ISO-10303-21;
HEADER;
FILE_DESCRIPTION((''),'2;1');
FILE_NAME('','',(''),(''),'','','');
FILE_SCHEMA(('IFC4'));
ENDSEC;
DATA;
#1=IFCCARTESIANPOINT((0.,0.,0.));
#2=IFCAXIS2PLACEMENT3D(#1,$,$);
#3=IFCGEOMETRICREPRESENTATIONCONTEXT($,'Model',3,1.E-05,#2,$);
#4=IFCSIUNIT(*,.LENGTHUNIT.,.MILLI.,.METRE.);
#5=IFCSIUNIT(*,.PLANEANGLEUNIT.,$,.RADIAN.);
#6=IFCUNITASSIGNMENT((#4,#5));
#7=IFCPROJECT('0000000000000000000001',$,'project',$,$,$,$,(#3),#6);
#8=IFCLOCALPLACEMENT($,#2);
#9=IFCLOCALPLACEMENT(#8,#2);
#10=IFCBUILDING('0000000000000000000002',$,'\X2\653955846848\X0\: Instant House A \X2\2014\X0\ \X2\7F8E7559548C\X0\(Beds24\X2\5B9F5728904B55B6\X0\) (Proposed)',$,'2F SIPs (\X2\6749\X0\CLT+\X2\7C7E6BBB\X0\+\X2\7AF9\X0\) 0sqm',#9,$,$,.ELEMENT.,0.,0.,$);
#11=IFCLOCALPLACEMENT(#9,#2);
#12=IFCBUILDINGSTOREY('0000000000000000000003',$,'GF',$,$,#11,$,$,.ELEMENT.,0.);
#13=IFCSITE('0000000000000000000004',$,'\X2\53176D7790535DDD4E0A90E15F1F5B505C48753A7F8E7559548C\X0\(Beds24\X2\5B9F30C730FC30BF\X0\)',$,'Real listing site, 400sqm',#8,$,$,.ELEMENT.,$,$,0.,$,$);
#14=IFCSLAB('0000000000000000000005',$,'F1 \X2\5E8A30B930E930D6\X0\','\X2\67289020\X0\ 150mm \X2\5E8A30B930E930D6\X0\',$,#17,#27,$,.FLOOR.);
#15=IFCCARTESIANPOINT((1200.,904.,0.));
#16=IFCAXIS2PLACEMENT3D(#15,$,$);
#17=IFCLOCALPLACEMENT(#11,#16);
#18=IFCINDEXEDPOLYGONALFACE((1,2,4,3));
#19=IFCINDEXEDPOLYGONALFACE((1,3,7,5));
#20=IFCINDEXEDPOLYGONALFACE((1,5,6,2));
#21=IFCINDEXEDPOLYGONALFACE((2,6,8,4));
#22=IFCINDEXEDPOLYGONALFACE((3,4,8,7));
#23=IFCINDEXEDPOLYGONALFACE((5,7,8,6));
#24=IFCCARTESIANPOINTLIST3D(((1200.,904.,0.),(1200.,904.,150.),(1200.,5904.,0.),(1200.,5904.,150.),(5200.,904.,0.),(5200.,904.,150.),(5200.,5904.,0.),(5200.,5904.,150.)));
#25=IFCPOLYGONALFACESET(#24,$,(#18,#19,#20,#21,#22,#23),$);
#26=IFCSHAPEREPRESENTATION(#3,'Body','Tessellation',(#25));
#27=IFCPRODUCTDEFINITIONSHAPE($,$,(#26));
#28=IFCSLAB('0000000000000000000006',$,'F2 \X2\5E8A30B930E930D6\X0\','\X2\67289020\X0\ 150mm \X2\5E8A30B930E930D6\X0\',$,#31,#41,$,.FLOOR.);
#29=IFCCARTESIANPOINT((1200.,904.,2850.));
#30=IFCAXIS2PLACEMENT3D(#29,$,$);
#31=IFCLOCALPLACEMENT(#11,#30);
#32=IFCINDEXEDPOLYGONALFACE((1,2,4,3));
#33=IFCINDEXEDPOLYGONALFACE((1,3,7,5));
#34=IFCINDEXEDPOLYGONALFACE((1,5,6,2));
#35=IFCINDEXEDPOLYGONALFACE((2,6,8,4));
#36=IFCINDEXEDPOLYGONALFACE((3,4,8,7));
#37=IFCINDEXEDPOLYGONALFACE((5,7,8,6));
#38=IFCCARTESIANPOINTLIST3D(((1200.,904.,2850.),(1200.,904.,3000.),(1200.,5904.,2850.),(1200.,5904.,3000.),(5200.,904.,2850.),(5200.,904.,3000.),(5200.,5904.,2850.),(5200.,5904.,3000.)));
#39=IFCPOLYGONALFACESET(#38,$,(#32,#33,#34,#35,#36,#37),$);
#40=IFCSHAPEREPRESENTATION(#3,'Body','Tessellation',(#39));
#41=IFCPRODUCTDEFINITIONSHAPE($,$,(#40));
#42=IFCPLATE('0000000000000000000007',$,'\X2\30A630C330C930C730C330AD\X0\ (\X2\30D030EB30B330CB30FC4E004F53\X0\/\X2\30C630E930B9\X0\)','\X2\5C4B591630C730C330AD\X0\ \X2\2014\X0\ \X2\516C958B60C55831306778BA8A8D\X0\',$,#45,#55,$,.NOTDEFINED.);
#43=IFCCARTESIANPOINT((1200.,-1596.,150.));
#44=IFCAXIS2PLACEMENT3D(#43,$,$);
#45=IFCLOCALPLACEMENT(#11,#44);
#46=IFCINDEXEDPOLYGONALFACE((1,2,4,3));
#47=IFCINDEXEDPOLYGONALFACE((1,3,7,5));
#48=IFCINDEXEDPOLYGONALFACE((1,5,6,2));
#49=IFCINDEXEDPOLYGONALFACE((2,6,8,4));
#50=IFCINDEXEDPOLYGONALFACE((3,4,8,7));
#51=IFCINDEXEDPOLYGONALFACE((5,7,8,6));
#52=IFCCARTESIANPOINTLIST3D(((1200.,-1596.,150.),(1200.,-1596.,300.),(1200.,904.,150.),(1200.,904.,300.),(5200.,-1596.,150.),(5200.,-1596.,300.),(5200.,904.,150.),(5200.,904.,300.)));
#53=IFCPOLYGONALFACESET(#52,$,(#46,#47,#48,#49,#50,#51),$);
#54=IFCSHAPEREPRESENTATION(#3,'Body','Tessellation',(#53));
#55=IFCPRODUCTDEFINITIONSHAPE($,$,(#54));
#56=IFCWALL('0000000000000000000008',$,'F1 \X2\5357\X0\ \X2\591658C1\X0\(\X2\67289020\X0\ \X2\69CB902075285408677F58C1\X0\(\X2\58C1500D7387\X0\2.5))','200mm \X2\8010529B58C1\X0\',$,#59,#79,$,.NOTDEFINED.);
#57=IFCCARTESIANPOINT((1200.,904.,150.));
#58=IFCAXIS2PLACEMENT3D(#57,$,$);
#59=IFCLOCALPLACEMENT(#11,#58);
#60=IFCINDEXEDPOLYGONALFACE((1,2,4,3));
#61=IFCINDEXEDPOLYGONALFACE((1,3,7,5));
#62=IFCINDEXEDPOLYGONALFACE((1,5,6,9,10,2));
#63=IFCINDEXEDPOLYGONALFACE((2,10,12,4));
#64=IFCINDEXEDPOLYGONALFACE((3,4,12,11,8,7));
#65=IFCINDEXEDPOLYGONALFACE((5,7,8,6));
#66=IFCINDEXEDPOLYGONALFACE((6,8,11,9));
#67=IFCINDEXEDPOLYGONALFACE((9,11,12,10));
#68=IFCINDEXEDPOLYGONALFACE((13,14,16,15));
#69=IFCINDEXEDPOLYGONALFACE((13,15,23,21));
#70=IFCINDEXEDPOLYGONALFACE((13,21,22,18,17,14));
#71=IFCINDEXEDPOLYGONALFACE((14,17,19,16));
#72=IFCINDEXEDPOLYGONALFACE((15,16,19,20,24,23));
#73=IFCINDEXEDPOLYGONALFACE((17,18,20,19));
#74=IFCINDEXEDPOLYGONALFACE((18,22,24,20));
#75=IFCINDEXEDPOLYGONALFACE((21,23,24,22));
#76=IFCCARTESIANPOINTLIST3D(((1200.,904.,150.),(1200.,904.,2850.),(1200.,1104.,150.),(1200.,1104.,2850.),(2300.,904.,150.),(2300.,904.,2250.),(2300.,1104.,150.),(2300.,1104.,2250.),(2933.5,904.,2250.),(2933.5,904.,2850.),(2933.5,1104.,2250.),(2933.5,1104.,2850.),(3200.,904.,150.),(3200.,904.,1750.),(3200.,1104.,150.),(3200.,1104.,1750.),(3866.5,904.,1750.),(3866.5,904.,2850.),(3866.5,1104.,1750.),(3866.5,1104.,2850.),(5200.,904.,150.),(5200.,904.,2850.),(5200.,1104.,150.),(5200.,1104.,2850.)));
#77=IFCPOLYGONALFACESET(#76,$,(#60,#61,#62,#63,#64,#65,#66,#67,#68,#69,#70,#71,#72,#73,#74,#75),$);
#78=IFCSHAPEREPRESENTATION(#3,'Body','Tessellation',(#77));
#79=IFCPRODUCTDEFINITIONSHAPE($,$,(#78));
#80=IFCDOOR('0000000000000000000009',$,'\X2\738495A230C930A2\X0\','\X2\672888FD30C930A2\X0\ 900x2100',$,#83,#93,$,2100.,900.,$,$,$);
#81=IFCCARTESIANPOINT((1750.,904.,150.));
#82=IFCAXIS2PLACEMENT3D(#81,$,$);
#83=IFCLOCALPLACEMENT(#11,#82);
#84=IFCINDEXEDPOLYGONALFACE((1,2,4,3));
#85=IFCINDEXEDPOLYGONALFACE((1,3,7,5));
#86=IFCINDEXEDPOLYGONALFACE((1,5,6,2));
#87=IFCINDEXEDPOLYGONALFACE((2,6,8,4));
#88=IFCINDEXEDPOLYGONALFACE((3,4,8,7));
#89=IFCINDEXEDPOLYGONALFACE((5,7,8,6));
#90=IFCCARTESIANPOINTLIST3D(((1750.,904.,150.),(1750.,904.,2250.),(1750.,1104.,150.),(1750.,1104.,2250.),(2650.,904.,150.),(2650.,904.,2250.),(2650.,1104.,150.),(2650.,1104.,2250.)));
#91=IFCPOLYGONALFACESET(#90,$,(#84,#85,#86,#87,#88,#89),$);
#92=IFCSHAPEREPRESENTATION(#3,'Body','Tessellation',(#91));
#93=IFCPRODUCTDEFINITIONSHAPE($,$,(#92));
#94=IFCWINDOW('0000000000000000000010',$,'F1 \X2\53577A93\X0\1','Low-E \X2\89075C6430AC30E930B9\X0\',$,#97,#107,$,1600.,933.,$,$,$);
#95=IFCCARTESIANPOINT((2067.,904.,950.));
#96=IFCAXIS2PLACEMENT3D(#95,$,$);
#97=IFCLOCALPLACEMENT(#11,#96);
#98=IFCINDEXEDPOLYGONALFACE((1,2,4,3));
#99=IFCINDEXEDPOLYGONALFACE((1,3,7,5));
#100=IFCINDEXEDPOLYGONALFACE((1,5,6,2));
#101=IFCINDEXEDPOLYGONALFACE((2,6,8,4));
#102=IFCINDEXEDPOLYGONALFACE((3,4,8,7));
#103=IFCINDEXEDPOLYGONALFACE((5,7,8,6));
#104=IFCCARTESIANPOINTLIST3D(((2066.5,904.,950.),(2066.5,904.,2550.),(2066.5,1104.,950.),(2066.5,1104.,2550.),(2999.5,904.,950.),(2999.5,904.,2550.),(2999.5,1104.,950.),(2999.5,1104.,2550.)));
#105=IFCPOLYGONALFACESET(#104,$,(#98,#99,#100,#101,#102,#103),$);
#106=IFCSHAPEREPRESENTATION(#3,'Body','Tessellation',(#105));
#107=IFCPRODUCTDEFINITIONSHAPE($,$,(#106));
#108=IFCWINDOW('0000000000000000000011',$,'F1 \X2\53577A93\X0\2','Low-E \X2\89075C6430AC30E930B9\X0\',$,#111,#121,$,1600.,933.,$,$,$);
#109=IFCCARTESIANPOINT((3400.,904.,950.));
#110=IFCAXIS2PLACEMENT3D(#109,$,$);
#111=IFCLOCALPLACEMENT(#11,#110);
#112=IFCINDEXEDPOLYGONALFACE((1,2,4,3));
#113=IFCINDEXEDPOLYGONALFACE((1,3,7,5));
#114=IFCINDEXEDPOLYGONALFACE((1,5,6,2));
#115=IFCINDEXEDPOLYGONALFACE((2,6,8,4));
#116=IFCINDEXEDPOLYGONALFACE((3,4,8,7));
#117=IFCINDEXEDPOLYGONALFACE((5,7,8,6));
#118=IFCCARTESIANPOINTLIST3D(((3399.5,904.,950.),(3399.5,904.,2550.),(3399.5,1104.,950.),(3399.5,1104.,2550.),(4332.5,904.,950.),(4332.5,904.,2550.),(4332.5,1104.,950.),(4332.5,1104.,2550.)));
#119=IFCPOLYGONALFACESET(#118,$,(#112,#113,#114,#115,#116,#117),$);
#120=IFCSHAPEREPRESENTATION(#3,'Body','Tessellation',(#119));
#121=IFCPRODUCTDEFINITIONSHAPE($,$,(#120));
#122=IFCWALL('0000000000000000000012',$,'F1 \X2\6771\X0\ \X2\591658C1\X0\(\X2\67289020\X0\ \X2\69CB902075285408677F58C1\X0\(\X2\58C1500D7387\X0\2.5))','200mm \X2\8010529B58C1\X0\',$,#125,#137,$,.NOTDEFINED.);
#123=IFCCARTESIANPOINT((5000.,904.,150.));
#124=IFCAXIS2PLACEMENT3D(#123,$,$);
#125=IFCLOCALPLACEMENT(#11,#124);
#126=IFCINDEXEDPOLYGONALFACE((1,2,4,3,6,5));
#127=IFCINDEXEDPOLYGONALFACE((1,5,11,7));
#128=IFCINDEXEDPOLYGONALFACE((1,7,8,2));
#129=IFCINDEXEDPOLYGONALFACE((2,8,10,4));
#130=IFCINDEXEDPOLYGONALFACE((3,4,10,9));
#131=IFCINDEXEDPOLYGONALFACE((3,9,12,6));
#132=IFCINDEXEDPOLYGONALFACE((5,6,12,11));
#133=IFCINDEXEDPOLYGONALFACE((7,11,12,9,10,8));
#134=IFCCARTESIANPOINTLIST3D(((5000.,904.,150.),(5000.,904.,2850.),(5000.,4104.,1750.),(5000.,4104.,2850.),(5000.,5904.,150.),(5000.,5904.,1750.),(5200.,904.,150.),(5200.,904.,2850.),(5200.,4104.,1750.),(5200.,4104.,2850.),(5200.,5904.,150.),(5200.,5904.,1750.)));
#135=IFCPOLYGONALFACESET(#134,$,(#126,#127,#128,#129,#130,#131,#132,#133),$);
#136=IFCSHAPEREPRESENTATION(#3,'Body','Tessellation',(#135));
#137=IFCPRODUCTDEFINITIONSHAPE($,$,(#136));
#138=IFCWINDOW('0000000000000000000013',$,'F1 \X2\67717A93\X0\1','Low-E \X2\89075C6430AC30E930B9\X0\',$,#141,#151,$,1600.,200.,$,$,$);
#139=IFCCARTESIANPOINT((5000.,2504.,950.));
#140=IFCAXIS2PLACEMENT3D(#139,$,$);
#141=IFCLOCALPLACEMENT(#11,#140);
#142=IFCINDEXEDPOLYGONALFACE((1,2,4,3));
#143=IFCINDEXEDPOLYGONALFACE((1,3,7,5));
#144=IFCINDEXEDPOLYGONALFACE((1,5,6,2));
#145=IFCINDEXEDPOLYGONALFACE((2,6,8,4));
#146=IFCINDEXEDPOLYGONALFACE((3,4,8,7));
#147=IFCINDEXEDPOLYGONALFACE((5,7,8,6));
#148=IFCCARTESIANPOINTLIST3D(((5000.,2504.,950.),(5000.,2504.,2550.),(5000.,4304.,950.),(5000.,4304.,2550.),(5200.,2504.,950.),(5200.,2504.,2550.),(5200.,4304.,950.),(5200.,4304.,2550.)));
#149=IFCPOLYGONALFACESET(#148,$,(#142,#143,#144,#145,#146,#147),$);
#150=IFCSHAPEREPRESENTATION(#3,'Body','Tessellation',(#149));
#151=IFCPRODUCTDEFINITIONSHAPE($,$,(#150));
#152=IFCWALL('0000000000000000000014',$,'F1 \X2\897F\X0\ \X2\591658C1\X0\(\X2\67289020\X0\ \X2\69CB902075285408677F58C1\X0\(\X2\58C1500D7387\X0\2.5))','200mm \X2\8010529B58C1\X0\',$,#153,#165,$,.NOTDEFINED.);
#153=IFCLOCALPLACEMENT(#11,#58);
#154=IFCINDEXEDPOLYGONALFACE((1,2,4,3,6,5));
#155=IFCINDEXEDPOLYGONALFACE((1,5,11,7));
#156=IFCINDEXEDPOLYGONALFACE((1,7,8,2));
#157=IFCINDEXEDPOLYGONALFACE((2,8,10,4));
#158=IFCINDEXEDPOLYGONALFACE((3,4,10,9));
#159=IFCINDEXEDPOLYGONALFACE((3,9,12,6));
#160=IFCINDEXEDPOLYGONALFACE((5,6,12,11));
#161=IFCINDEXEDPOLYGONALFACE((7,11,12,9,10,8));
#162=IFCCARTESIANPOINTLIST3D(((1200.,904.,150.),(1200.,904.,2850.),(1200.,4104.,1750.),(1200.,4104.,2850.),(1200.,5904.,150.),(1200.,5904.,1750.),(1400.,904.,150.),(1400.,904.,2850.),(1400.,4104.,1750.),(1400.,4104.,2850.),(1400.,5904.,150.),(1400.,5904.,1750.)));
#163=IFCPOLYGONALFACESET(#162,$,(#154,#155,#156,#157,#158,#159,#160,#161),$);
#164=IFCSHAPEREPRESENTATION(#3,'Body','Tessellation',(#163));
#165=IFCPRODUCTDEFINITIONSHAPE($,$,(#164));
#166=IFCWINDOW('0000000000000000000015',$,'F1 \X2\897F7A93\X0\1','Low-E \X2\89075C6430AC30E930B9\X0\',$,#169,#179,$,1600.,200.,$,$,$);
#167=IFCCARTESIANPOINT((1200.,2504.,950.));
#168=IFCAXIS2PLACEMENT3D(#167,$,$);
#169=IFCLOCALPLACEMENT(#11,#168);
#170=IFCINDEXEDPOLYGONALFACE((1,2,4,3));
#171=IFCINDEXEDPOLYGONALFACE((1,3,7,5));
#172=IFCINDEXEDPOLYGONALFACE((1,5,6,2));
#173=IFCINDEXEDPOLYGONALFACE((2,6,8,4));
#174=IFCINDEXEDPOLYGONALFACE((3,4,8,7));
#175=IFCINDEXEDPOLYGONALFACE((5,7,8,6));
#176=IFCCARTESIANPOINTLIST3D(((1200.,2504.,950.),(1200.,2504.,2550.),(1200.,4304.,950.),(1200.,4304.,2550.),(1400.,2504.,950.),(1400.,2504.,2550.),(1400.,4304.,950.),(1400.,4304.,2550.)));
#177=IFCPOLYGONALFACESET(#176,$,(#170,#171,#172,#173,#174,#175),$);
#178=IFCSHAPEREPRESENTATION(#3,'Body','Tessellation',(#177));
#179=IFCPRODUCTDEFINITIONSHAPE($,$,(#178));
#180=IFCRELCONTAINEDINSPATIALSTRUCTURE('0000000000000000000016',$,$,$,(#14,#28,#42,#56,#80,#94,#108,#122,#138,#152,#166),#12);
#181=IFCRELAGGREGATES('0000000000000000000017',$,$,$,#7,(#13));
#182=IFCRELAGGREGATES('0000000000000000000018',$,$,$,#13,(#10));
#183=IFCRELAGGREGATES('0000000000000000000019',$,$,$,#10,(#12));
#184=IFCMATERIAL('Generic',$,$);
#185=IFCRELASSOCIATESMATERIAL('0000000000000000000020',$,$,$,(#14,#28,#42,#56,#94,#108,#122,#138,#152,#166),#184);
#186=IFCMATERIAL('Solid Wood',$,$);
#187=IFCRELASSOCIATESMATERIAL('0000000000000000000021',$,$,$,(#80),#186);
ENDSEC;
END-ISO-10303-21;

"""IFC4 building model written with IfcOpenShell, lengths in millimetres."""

from ifc_helpers import new_model, si_unit, frame, frame_2d, origin, place, context, project, spatial, rectangle, extrude, material, element, fill, save


model = new_model("IFC4")

# Units and contexts
model_context = context("Model", 3, precision=1e-05, world=origin())
ifc_project = project(units=[si_unit("LENGTHUNIT", "METRE", prefix="MILLI"), si_unit("PLANEANGLEUNIT", "RADIAN")], contexts=[model_context])

# Site, building, storey
site_placement = place(None, origin())
site = spatial("IfcSite", under=ifc_project, at=site_placement, Name="北海道川上郡弟子屈町美留和(Beds24実データ)", ObjectType="Real listing site, 400sqm", CompositionType="ELEMENT", RefElevation=0.0)
building_placement = place(site_placement, origin())
building = spatial("IfcBuilding", under=site, at=building_placement, Name="改善案: Instant House A — 美留和(Beds24実在運営) (Proposed)", ObjectType="2F SIPs (杉CLT+籾殻+竹) 0sqm", CompositionType="ELEMENT", ElevationOfRefHeight=0.0, ElevationOfTerrain=0.0)
storey_placement = place(building_placement, origin())
storey = spatial("IfcBuildingStorey", under=building, at=storey_placement, Name="GF", CompositionType="ELEMENT", Elevation=0.0)

# Slabs
ifc_material_1 = material(Name="Generic")
slab_1_placement = place(storey_placement, frame((1200.0, 904.0, 0.0)))
element("IfcSlab", 1, at=slab_1_placement, inside=storey, material=ifc_material_1, Name="F1 床スラブ", Description="木造 150mm 床スラブ", PredefinedType="FLOOR", context=model_context, shape_type="SweptSolid", body=[
    extrude(rectangle(XDim=4000.0, YDim=5000.0, at=frame_2d((2000.0, 2500.0))), frame((1200.0, 904.0, 0.0)), (0.0, 0.0, 1.0), 150.0),
])
slab_2_placement = place(storey_placement, frame((1200.0, 904.0, 2850.0)))
element("IfcSlab", 2, at=slab_2_placement, inside=storey, material=ifc_material_1, Name="F2 床スラブ", Description="木造 150mm 床スラブ", PredefinedType="FLOOR", context=model_context, shape_type="SweptSolid", body=[
    extrude(rectangle(XDim=4000.0, YDim=5000.0, at=frame_2d((2000.0, 2500.0))), frame((1200.0, 904.0, 2850.0)), (0.0, 0.0, 1.0), 150.0),
])

# Plate
plate_placement = place(storey_placement, frame((1200.0, -1596.0, 150.0)))
element("IfcPlate", 3, at=plate_placement, inside=storey, material=ifc_material_1, Name="ウッドデッキ (バルコニー一体/テラス)", Description="屋外デッキ — 公開情報で確認", PredefinedType="NOTDEFINED", context=model_context, shape_type="SweptSolid", body=[
    extrude(rectangle(XDim=4000.0, YDim=2500.0, at=frame_2d((2000.0, 1250.0))), frame((1200.0, -1596.0, 150.0)), (0.0, 0.0, 1.0), 150.0),
])

# Wall, openings, door, windows
wall_1_placement = place(storey_placement, frame((1200.0, 904.0, 150.0)))
wall_1 = element("IfcWall", 4, at=wall_1_placement, inside=storey, material=ifc_material_1, Name="F1 南 外壁(木造 構造用合板壁(壁倍率2.5))", Description="200mm 耐力壁", PredefinedType="NOTDEFINED", context=model_context, shape_type="SweptSolid", body=[
    extrude(rectangle(XDim=4000.0, YDim=200.0, at=frame_2d((2000.0, 100.0))), frame((1200.0, 904.0, 150.0)), (0.0, 0.0, 1.0), 2700.0),
])
opening_1_placement = place(storey_placement, frame((1750.0, 904.0, 150.0)))
opening_1 = element("IfcOpeningElement", 5, at=opening_1_placement, cuts=wall_1, PredefinedType="NOTDEFINED", context=model_context, shape_type="SweptSolid", body=[
    extrude(rectangle(XDim=900.0, YDim=200.0, at=frame_2d((450.0, 100.0))), frame((1750.0, 904.0, 150.0)), (0.0, 0.0, 1.0), 2100.0),
])
opening_2_placement = place(storey_placement, frame((2067.0, 904.0, 950.0)))
opening_2 = element("IfcOpeningElement", 6, at=opening_2_placement, cuts=wall_1, PredefinedType="NOTDEFINED", context=model_context, shape_type="SweptSolid", body=[
    extrude(rectangle(XDim=933.0, YDim=200.0, at=frame_2d((466.0, 100.0))), frame((2067.0, 904.0, 950.0)), (0.0, 0.0, 1.0), 1600.0),
])
opening_3_placement = place(storey_placement, frame((3400.0, 904.0, 950.0)))
opening_3 = element("IfcOpeningElement", 7, at=opening_3_placement, cuts=wall_1, PredefinedType="NOTDEFINED", context=model_context, shape_type="SweptSolid", body=[
    extrude(rectangle(XDim=933.0, YDim=200.0, at=frame_2d((466.0, 100.0))), frame((3400.0, 904.0, 950.0)), (0.0, 0.0, 1.0), 1600.0),
])
ifc_material_2 = material(Name="Solid Wood")
door_placement = place(storey_placement, frame((1750.0, 904.0, 150.0)))
door = element("IfcDoor", 8, at=door_placement, inside=storey, material=ifc_material_2, Name="玄関ドア", Description="木製ドア 900x2100", OverallHeight=2100.0, OverallWidth=900.0, context=model_context, shape_type="SweptSolid", body=[
    extrude(rectangle(XDim=900.0, YDim=200.0, at=frame_2d((450.0, 100.0))), frame((1750.0, 904.0, 150.0)), (0.0, 0.0, 1.0), 2100.0),
])
fill(opening_1, door)
window_1_placement = place(storey_placement, frame((2067.0, 904.0, 950.0)))
window_1 = element("IfcWindow", 9, at=window_1_placement, inside=storey, material=ifc_material_1, Name="F1 南窓1", Description="Low-E 複層ガラス", OverallHeight=1600.0, OverallWidth=933.0, context=model_context, shape_type="SweptSolid", body=[
    extrude(rectangle(XDim=933.0, YDim=200.0, at=frame_2d((466.0, 100.0))), frame((2067.0, 904.0, 950.0)), (0.0, 0.0, 1.0), 1600.0),
])
fill(opening_2, window_1)
window_2_placement = place(storey_placement, frame((3400.0, 904.0, 950.0)))
window_2 = element("IfcWindow", 10, at=window_2_placement, inside=storey, material=ifc_material_1, Name="F1 南窓2", Description="Low-E 複層ガラス", OverallHeight=1600.0, OverallWidth=933.0, context=model_context, shape_type="SweptSolid", body=[
    extrude(rectangle(XDim=933.0, YDim=200.0, at=frame_2d((466.0, 100.0))), frame((3400.0, 904.0, 950.0)), (0.0, 0.0, 1.0), 1600.0),
])
fill(opening_3, window_2)

# Walls, openings, windows
wall_2_placement = place(storey_placement, frame((5000.0, 904.0, 150.0)))
wall_2 = element("IfcWall", 11, at=wall_2_placement, inside=storey, material=ifc_material_1, Name="F1 東 外壁(木造 構造用合板壁(壁倍率2.5))", Description="200mm 耐力壁", PredefinedType="NOTDEFINED", context=model_context, shape_type="SweptSolid", body=[
    extrude(rectangle(XDim=200.0, YDim=5000.0, at=frame_2d((100.0, 2500.0))), frame((5000.0, 904.0, 150.0)), (0.0, 0.0, 1.0), 2700.0),
])
opening_4_placement = place(storey_placement, frame((5000.0, 2504.0, 950.0)))
opening_4 = element("IfcOpeningElement", 12, at=opening_4_placement, cuts=wall_2, PredefinedType="NOTDEFINED", context=model_context, shape_type="SweptSolid", body=[
    extrude(rectangle(XDim=200.0, YDim=1800.0, at=frame_2d((100.0, 900.0))), frame((5000.0, 2504.0, 950.0)), (0.0, 0.0, 1.0), 1600.0),
])
window_3_placement = place(storey_placement, frame((5000.0, 2504.0, 950.0)))
window_3 = element("IfcWindow", 13, at=window_3_placement, inside=storey, material=ifc_material_1, Name="F1 東窓1", Description="Low-E 複層ガラス", OverallHeight=1600.0, OverallWidth=200.0, context=model_context, shape_type="SweptSolid", body=[
    extrude(rectangle(XDim=200.0, YDim=1800.0, at=frame_2d((100.0, 900.0))), frame((5000.0, 2504.0, 950.0)), (0.0, 0.0, 1.0), 1600.0),
])
fill(opening_4, window_3)
wall_3_placement = place(storey_placement, frame((1200.0, 904.0, 150.0)))
wall_3 = element("IfcWall", 14, at=wall_3_placement, inside=storey, material=ifc_material_1, Name="F1 西 外壁(木造 構造用合板壁(壁倍率2.5))", Description="200mm 耐力壁", PredefinedType="NOTDEFINED", context=model_context, shape_type="SweptSolid", body=[
    extrude(rectangle(XDim=200.0, YDim=5000.0, at=frame_2d((100.0, 2500.0))), frame((1200.0, 904.0, 150.0)), (0.0, 0.0, 1.0), 2700.0),
])
opening_5_placement = place(storey_placement, frame((1200.0, 2504.0, 950.0)))
opening_5 = element("IfcOpeningElement", 15, at=opening_5_placement, cuts=wall_3, PredefinedType="NOTDEFINED", context=model_context, shape_type="SweptSolid", body=[
    extrude(rectangle(XDim=200.0, YDim=1800.0, at=frame_2d((100.0, 900.0))), frame((1200.0, 2504.0, 950.0)), (0.0, 0.0, 1.0), 1600.0),
])
window_4_placement = place(storey_placement, frame((1200.0, 2504.0, 950.0)))
window_4 = element("IfcWindow", 16, at=window_4_placement, inside=storey, material=ifc_material_1, Name="F1 西窓1", Description="Low-E 複層ガラス", OverallHeight=1600.0, OverallWidth=200.0, context=model_context, shape_type="SweptSolid", body=[
    extrude(rectangle(XDim=200.0, YDim=1800.0, at=frame_2d((100.0, 900.0))), frame((1200.0, 2504.0, 950.0)), (0.0, 0.0, 1.0), 1600.0),
])
fill(opening_5, window_4)

save(model, "model.ifc")
